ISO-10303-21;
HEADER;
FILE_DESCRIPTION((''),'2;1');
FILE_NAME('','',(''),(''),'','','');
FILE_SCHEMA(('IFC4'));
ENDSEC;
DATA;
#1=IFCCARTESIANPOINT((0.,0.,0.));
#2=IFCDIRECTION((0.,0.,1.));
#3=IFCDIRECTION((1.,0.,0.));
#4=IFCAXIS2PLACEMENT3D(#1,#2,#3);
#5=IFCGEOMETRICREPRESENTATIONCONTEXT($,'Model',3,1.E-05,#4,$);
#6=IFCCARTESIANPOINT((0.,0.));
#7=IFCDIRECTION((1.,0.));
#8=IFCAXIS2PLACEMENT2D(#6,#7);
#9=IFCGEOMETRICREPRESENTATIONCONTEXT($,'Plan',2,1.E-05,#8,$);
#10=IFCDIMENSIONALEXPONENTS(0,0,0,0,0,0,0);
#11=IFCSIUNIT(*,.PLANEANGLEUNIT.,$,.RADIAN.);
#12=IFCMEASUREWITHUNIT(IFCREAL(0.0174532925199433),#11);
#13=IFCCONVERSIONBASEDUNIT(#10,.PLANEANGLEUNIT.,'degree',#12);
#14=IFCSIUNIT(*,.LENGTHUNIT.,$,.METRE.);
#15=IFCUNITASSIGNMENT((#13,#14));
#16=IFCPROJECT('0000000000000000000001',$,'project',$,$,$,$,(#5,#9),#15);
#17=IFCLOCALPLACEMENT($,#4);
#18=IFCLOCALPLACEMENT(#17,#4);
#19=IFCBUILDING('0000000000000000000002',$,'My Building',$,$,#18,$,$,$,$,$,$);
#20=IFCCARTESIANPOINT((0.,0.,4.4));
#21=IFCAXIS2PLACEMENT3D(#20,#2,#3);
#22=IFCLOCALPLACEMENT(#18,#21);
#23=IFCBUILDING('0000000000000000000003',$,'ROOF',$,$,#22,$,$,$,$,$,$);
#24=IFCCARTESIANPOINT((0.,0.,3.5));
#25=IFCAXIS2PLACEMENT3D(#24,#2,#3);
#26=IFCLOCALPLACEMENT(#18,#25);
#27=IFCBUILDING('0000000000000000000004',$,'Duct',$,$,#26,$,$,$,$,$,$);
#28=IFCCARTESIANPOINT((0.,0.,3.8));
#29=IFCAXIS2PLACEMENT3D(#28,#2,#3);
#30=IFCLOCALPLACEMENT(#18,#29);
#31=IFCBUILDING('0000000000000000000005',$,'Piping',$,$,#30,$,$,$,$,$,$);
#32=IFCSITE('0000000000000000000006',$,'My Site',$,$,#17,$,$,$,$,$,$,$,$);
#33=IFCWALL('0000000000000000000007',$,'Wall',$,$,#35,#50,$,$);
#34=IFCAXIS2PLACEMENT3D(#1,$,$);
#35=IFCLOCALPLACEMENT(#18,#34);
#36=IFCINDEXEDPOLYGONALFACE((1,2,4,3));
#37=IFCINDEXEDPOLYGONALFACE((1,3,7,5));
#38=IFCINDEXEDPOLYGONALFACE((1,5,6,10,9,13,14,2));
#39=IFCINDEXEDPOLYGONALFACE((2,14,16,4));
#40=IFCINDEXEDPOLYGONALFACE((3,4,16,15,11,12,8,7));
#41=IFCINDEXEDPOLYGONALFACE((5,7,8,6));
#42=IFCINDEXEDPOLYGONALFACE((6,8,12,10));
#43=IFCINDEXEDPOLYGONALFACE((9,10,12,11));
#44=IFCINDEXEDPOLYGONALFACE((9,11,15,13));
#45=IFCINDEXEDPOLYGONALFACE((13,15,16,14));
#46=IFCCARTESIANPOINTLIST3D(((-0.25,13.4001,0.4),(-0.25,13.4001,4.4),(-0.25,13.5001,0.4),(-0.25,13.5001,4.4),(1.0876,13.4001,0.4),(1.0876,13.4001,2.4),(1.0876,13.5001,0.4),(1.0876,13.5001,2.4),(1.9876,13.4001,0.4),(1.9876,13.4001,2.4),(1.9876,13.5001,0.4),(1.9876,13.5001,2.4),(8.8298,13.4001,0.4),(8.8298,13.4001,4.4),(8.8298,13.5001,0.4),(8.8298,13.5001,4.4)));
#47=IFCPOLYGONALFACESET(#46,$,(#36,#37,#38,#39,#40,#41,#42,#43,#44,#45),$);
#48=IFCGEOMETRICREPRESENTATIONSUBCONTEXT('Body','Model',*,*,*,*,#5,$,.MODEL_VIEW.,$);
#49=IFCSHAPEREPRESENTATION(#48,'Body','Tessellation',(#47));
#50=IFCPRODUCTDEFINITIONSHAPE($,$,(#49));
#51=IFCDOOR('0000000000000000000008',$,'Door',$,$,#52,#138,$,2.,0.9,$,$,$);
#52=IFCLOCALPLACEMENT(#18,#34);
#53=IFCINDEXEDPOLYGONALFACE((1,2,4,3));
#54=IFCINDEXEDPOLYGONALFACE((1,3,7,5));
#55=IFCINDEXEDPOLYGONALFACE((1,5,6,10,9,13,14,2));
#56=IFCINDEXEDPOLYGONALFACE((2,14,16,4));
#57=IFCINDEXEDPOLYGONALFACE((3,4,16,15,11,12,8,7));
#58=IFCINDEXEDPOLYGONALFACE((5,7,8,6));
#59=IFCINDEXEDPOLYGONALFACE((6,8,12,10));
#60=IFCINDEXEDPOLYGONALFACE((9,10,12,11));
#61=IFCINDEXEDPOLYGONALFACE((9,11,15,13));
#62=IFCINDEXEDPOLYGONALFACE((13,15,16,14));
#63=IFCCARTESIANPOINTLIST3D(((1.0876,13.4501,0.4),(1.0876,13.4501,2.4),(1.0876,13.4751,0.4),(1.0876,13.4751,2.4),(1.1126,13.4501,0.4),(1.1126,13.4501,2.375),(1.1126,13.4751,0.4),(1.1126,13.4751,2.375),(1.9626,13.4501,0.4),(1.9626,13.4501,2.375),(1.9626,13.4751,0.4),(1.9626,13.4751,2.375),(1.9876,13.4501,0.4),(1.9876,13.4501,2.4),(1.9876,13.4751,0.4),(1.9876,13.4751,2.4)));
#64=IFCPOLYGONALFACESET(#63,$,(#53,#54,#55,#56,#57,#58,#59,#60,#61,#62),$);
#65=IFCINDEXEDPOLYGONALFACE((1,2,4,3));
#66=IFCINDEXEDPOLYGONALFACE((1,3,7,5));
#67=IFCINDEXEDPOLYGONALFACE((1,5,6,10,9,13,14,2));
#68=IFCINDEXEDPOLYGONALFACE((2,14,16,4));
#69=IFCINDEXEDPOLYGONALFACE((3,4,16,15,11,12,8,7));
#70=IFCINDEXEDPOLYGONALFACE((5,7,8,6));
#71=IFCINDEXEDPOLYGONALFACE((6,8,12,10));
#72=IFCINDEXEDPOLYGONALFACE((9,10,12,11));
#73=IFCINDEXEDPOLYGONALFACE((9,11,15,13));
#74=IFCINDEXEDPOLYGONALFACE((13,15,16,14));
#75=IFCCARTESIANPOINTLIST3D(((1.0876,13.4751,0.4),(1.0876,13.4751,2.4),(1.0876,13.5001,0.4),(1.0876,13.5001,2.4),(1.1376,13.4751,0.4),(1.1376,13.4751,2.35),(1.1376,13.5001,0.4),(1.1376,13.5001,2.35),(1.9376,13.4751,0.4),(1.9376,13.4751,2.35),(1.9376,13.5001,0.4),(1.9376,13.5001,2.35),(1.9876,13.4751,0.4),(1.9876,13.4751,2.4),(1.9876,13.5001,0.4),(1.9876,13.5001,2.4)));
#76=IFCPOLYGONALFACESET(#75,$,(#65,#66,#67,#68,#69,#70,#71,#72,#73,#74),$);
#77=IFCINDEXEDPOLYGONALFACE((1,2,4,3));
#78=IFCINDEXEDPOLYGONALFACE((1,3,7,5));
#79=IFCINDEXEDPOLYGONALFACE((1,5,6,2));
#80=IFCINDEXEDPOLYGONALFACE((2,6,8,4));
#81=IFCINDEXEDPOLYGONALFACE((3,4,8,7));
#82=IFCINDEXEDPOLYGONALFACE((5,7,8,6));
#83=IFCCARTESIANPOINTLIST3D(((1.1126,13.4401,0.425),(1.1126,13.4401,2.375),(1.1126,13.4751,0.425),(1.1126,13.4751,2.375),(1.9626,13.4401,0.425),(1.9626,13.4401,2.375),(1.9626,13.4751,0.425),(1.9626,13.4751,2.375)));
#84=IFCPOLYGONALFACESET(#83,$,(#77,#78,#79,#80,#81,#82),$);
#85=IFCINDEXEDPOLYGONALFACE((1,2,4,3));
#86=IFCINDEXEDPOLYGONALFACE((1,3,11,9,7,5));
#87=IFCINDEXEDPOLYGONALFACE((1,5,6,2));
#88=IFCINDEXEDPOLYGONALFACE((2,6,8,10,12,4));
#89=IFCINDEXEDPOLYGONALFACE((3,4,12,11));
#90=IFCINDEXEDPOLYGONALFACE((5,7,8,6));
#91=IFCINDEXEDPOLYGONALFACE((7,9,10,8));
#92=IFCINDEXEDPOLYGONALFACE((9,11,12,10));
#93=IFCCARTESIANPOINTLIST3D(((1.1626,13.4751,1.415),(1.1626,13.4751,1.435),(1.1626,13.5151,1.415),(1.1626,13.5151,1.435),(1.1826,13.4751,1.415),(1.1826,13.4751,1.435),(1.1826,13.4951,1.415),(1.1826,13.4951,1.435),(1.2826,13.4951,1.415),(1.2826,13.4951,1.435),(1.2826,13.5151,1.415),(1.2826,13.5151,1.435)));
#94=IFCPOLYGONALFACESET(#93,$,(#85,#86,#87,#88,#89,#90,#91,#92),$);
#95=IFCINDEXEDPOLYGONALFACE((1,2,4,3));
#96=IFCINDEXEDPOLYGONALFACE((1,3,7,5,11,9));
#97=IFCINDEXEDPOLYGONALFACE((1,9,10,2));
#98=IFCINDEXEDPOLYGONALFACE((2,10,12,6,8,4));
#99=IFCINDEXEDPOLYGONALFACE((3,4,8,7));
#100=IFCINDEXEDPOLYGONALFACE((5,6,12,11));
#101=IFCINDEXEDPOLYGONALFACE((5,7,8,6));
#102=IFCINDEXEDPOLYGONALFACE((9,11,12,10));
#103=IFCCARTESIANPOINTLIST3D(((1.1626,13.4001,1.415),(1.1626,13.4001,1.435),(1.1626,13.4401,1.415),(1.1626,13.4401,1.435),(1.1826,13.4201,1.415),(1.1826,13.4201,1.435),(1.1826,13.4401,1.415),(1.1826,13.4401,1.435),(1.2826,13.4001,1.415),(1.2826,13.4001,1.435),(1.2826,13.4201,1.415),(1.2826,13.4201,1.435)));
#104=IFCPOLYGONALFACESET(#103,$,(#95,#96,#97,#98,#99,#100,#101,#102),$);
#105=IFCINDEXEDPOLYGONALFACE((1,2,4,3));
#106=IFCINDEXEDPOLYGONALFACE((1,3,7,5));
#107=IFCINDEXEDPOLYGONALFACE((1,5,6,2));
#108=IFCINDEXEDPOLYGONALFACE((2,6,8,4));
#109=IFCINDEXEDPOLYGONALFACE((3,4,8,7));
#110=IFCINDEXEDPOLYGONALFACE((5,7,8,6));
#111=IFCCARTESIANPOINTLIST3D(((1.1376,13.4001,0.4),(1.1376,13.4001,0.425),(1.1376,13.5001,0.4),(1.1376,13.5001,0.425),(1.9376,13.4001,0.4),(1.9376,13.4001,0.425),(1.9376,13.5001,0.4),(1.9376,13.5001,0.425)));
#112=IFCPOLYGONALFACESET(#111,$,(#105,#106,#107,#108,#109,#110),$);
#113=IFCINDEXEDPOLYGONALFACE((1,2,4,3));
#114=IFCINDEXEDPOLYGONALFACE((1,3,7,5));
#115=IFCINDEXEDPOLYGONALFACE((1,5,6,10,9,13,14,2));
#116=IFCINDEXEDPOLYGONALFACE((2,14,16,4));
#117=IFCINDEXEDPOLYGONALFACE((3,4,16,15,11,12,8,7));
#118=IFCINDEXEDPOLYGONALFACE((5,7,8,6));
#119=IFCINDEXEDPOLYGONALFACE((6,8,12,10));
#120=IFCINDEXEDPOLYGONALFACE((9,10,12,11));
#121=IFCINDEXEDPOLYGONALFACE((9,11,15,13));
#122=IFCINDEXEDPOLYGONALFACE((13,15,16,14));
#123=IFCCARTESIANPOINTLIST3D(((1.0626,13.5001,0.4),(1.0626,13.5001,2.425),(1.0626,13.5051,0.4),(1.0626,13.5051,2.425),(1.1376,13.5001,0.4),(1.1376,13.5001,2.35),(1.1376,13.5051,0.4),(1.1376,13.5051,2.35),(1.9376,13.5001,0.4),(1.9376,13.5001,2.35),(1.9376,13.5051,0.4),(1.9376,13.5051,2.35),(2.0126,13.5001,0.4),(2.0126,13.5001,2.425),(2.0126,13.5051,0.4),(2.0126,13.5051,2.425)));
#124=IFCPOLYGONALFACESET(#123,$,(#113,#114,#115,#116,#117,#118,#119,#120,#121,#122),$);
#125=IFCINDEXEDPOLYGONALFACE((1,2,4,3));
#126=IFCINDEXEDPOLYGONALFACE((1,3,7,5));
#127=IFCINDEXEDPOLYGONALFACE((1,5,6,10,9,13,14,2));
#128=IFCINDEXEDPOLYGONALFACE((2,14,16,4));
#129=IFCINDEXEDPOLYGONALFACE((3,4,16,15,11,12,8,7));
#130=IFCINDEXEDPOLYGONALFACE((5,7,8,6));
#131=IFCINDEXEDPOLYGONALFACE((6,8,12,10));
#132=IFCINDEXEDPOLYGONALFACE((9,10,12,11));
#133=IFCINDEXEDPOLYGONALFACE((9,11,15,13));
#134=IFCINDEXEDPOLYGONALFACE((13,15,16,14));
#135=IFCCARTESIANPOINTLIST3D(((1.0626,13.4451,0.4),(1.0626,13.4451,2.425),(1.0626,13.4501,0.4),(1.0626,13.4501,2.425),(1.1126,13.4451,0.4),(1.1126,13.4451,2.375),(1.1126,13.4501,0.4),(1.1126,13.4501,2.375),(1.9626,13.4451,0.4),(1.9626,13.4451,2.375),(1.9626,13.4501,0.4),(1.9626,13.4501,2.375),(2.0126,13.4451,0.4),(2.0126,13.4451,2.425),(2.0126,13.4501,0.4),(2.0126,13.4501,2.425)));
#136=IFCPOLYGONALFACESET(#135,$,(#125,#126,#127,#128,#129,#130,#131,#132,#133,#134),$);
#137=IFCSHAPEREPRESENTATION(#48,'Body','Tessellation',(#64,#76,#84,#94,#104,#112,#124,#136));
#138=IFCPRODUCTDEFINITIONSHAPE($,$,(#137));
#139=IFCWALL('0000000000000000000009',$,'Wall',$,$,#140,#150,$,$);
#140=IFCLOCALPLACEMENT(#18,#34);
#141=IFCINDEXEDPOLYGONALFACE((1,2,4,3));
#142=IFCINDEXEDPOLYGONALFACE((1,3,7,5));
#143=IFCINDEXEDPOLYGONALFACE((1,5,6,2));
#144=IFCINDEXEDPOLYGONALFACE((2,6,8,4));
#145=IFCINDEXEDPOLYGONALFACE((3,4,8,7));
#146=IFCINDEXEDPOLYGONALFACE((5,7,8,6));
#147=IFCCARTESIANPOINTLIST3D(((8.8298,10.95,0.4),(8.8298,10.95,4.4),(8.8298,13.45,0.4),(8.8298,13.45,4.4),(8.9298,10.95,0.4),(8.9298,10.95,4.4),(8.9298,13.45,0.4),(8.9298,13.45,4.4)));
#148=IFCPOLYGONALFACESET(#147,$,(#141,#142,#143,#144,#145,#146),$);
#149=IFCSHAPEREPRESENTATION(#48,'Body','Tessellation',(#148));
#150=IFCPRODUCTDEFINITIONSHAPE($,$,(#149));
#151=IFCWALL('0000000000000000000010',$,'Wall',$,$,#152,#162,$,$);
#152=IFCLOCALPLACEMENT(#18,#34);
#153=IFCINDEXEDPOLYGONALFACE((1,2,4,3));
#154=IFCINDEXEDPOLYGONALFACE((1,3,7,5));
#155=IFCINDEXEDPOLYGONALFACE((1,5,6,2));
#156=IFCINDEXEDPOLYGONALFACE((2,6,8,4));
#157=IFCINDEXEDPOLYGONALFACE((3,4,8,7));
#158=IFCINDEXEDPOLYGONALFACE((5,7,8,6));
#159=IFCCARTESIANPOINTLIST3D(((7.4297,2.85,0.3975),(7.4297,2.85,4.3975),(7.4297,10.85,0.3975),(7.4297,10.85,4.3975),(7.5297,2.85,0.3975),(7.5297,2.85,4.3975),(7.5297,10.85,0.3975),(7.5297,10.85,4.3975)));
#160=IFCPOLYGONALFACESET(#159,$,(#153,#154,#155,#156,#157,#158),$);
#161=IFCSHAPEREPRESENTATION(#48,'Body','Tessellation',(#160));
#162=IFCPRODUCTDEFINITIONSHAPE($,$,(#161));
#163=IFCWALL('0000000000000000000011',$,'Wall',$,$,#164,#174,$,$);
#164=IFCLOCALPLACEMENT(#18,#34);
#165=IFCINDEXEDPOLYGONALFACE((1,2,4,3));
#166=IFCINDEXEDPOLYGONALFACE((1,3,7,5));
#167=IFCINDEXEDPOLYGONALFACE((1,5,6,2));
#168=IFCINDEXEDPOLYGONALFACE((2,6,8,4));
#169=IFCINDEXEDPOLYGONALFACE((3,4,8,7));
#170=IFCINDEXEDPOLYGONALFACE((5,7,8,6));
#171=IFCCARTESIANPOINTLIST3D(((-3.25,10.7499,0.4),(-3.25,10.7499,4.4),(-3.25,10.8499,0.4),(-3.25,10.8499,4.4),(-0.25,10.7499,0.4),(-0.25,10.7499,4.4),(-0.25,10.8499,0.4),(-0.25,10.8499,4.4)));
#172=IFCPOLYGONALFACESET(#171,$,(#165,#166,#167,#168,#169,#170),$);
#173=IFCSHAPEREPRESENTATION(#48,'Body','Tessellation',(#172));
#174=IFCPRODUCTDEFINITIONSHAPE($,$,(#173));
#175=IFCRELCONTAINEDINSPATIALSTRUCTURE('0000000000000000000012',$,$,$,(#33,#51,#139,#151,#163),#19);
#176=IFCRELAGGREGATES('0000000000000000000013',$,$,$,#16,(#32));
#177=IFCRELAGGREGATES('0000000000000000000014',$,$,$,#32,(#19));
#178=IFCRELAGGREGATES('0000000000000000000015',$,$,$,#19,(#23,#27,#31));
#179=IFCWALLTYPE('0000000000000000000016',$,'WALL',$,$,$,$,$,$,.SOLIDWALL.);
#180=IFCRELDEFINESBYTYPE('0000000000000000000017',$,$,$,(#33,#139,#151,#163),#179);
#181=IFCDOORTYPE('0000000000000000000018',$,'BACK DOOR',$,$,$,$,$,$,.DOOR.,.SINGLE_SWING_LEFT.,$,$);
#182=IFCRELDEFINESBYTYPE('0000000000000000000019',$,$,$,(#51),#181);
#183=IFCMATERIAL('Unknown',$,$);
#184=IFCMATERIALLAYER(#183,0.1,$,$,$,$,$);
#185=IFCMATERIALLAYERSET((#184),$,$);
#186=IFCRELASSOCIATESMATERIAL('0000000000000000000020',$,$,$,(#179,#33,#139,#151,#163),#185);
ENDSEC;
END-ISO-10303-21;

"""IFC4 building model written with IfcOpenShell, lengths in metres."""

from ifc_helpers import new_model, entity, si_unit, converted_unit, frame, origin_with_axes, origin_2d_with_axis, place, context, subcontext, project, spatial, line, indexed_curve, outline, extrude, shape, source, transform, mapped, material, layer, layer_set, layer_usage, type_object, type_shapes, element, fill, save


model = new_model("IFC4")

# Units and contexts
model_context = context("Model", 3, precision=1e-05, world=origin_with_axes())
plan_context = context("Plan", 2, precision=1e-05, world=origin_2d_with_axis())
body_context_1 = subcontext(model_context, "Body", "Model", "MODEL_VIEW")
body_context_2 = subcontext(plan_context, "Body", "Plan", "PLAN_VIEW")
ifc_project = project(units=[converted_unit("PLANEANGLEUNIT", "degree", entity("IfcReal", 0.0174532925199433), si_unit("PLANEANGLEUNIT", "RADIAN"), dimensions=[0, 0, 0, 0, 0, 0, 0]), si_unit("LENGTHUNIT", "METRE")], contexts=[model_context, plan_context])

# Site, building
site_placement = place(None, origin_with_axes())
site = spatial("IfcSite", under=ifc_project, at=site_placement, Name="My Site")
building_1_placement = place(site_placement, origin_with_axes())
building_1 = spatial("IfcBuilding", under=site, at=building_1_placement, Name="My Building")

# Shared definitions
ifc_material = material(Name="Unknown")

# Shared definitions
building_2_placement = place(building_1_placement, frame((0.0, 0.0, 4.4), z_axis=(0.0, 0.0, 1.0), x_axis=(1.0, 0.0, 0.0)))
building_2 = spatial("IfcBuilding", under=building_1, at=building_2_placement, Name="ROOF")

# Shared definitions
ifc_layer_1 = layer(ifc_material, 0.1)
ifc_layer_set_1 = layer_set([ifc_layer_1])
wall_type_1 = type_object("IfcWallType", Name="WALL", PredefinedType="SOLIDWALL", material=ifc_layer_set_1)
shared_shape_1 = source(origin_with_axes(), body_context_1, "Body", "SweptSolid", [
    extrude(outline(indexed_curve([(0.0, 0.0), (0.9, 0.0), (0.9, 2.0), (0.0, 2.0)], segments=[line(1, 2, 3, 4, 1)])), frame((0.0, -0.6, 0.0), z_axis=(0.0, -1.0, 0.0), x_axis=(1.0, 0.0, 0.0)), (0.0, 0.0, -1.0), 1.2),
])
door_type = type_object("IfcDoorType", Name="BACK DOOR", OperationType="SINGLE_SWING_LEFT", PredefinedType="DOOR")
shared_shape_2 = source(origin_with_axes(), body_context_1, "Body", "SweptSolid", [
    extrude(outline(indexed_curve([(0.0, 0.0), (0.0, 2.0), (0.9, 2.0), (0.9, 0.0), (0.875, 0.0), (0.875, 1.975), (0.025, 1.975), (0.025, 0.0)], segments=[line(1, 2, 3, 4, 5, 6, 7, 8, 1)])), frame((0.0, 0.025, 0.0), z_axis=(0.0, -1.0, 0.0), x_axis=(1.0, 0.0, 0.0)), (0.0, 0.0, -1.0), 0.025),
    extrude(outline(indexed_curve([(0.0, 0.0), (0.0, 2.0), (0.9, 2.0), (0.9, 0.0), (0.85, 0.0), (0.85, 1.95), (0.05, 1.95), (0.05, 0.0)], segments=[line(1, 2, 3, 4, 5, 6, 7, 8, 1)])), frame((0.0, 0.0, 0.0), z_axis=(0.0, -1.0, 0.0), x_axis=(1.0, 0.0, 0.0)), (0.0, 0.0, -1.0), 0.025),
    extrude(outline(indexed_curve([(0.0, 0.0), (0.85, 0.0), (0.85, 0.035), (0.0, 0.035)], segments=[line(1, 2, 3, 4, 1)])), frame((0.025, 0.025, 0.025), z_axis=(0.0, 0.0, 1.0), x_axis=(1.0, 0.0, 0.0)), (0.0, 0.0, 1.0), 1.95),
    extrude(outline(indexed_curve([(0.0, 0.0), (0.0, -0.04), (-0.12, -0.04), (-0.12, -0.02), (-0.02, -0.02), (-0.02, 0.0)], segments=[line(1, 2, 3, 4, 5, 6, 1)])), frame((0.825, 0.025, 1.015), z_axis=(0.0, 0.0, 1.0), x_axis=(1.0, 0.0, 0.0)), (0.0, 0.0, 1.0), 0.02),
    extrude(outline(indexed_curve([(0.0, 0.0), (0.0, 0.04), (-0.12, 0.04), (-0.12, 0.02), (-0.02, 0.02), (-0.02, 0.0)], segments=[line(1, 2, 3, 4, 5, 6, 1)])), frame((0.825, 0.06, 1.015), z_axis=(0.0, 0.0, 1.0), x_axis=(1.0, 0.0, 0.0)), (0.0, 0.0, 1.0), 0.02),
    extrude(outline(indexed_curve([(0.0, 0.0), (0.8, 0.0), (0.8, 0.1), (0.0, 0.1)], segments=[line(1, 2, 3, 4, 1)])), frame((0.05, 0.0, 0.0), z_axis=(0.0, 0.0, 1.0), x_axis=(1.0, 0.0, 0.0)), (0.0, 0.0, 1.0), 0.025),
    extrude(outline(indexed_curve([(0.0, 0.0), (0.0, 2.025), (0.95, 2.025), (0.95, 0.0), (0.875, 0.0), (0.875, 1.95), (0.075, 1.95), (0.075, 0.0)], segments=[line(1, 2, 3, 4, 5, 6, 7, 8, 1)])), frame((-0.025, -0.005, 0.0), z_axis=(0.0, -1.0, 0.0), x_axis=(1.0, 0.0, 0.0)), (0.0, 0.0, -1.0), 0.005),
    extrude(outline(indexed_curve([(0.0, 0.0), (0.0, 2.025), (0.95, 2.025), (0.95, 0.0), (0.9, 0.0), (0.9, 1.975), (0.05, 1.975), (0.05, 0.0)], segments=[line(1, 2, 3, 4, 5, 6, 7, 8, 1)])), frame((-0.025, 0.05, 0.0), z_axis=(0.0, -1.0, 0.0), x_axis=(1.0, 0.0, 0.0)), (0.0, 0.0, -1.0), 0.005),
])
shared_shape_3 = source(origin_with_axes(), body_context_2, "Body", "Curve2D", [
    entity("IfcIndexedPolyCurve", entity("IfcCartesianPointList2D", [[0.0, 0.0], [0.0, 0.05], [0.025, 0.05], [0.025, 0.025], [0.05, 0.025], [0.05, 0.0]]), [entity("IfcLineIndex", [1, 2, 3, 4, 5, 6, 1])]),
    entity("IfcIndexedPolyCurve", entity("IfcCartesianPointList2D", [[0.9, 0.0], [0.9, 0.05], [0.875, 0.05], [0.875, 0.025], [0.85, 0.025], [0.85, 0.0]]), [entity("IfcLineIndex", [1, 2, 3, 4, 5, 6, 1])]),
    entity("IfcTrimmedCurve", entity("IfcEllipse", entity("IfcAxis2Placement2D", entity("IfcCartesianPoint", [0.06, 0.05]), entity("IfcDirection", [1.0, 0.0])), 0.815, 0.85), [entity("IfcCartesianPoint", [0.875, 0.05])], [entity("IfcCartesianPoint", [0.06, 0.9])], True, "CARTESIAN"),
    entity("IfcIndexedPolyCurve", entity("IfcCartesianPointList2D", [[0.025, 0.05], [0.06, 0.05], [0.06, 0.9], [0.025, 0.9]]), [entity("IfcLineIndex", [1, 2, 3, 4, 1])]),
])
type_shapes(door_type, [shared_shape_2, shared_shape_3])

# Wall, opening, door
ifc_layer_usage_1 = layer_usage(ifc_layer_set_1, "AXIS2", "POSITIVE", 0.0)
wall_1_placement = place(building_1_placement, frame((8.8298, 13.5001, 0.4), z_axis=(0.0, 0.0, 1.0), x_axis=(-1.0, 0.0, 0.0)))
wall_1 = element("IfcWall", 1, at=wall_1_placement, inside=building_1, type_object=wall_type_1, material=ifc_layer_usage_1, Name="Wall", context=body_context_1, shape_type="SweptSolid", body=[
    extrude(outline(indexed_curve([(0.0, 0.0), (0.0, 0.1), (9.0798, 0.1), (9.0798, 0.0)], segments=[line(1, 2, 3, 4, 1)])), origin_with_axes(), (0.0, 0.0, 1.0), 4.0),
])
opening_1_placement = place(wall_1_placement, frame((6.8422, 0.0, 0.0), z_axis=(0.0, 0.0, 1.0), x_axis=(1.0, 0.0, 0.0)))
opening_1 = element("IfcOpeningElement", 2, at=opening_1_placement, cuts=wall_1, PredefinedType="OPENING", context=body_context_1, shape_type="MappedRepresentation", body=[
    mapped(shared_shape_1, transform((0.0, 0.0, 0.0), x_axis=(1.0, 0.0, 0.0), y_axis=(0.0, 1.0, 0.0), z_axis=(0.0, 0.0, 1.0), scale=1.0)),
])
door_1_placement = place(opening_1_placement, frame((0.0, 0.0, 0.0), z_axis=(0.0, 0.0, 1.0), x_axis=(1.0, 0.0, 0.0)))
door_1 = element("IfcDoor", 3, at=door_1_placement, inside=building_1, type_object=door_type, Name="Door", OverallHeight=2.0, OverallWidth=0.9, shapes=[
    shape(body_context_1, "Body", "MappedRepresentation", [mapped(shared_shape_2, transform((0.0, 0.0, 0.0), x_axis=(1.0, 0.0, 0.0), y_axis=(0.0, 1.0, 0.0), z_axis=(0.0, 0.0, 1.0), scale=1.0))]),
    shape(body_context_2, "Body", "MappedRepresentation", [mapped(shared_shape_3, transform((0.0, 0.0, 0.0), x_axis=(1.0, 0.0, 0.0), y_axis=(0.0, 1.0, 0.0), z_axis=(0.0, 0.0, 1.0), scale=1.0))]),
])
fill(opening_1, door_1)

# Walls
ifc_layer_usage_2 = layer_usage(ifc_layer_set_1, "AXIS2", "POSITIVE", 0.0)
wall_2_placement = place(building_1_placement, frame((8.8298, 13.45, 0.4), z_axis=(0.0, 0.0, 1.0), x_axis=(0.0, -1.0, 0.0)))
element("IfcWall", 4, at=wall_2_placement, inside=building_1, type_object=wall_type_1, material=ifc_layer_usage_2, Name="Wall", context=body_context_1, shape_type="SweptSolid", body=[
    extrude(outline(indexed_curve([(0.0, 0.0), (0.0, 0.1), (2.5, 0.1), (2.5, 0.0)], segments=[line(1, 2, 3, 4, 1)])), origin_with_axes(), (0.0, 0.0, 1.0), 4.0),
])
ifc_layer_usage_3 = layer_usage(ifc_layer_set_1, "AXIS2", "POSITIVE", 0.0)
wall_3_placement = place(building_1_placement, frame((7.4297, 10.85, 0.3975), z_axis=(0.0, 0.0, 1.0), x_axis=(0.0, -1.0, 0.0)))
element("IfcWall", 5, at=wall_3_placement, inside=building_1, type_object=wall_type_1, material=ifc_layer_usage_3, Name="Wall", context=body_context_1, shape_type="SweptSolid", body=[
    extrude(outline(indexed_curve([(0.0, 0.0), (0.0, 0.1), (8.0, 0.1), (8.0, 0.0)], segments=[line(1, 2, 3, 4, 1)])), origin_with_axes(), (0.0, 0.0, 1.0), 4.0),
])
ifc_layer_usage_4 = layer_usage(ifc_layer_set_1, "AXIS2", "POSITIVE", 0.0)
wall_4_placement = place(building_1_placement, frame((-3.25, 10.7499, 0.4), z_axis=(0.0, 0.0, 1.0), x_axis=(1.0, 0.0, 0.0)))
element("IfcWall", 6, at=wall_4_placement, inside=building_1, type_object=wall_type_1, material=ifc_layer_usage_4, Name="Wall", context=body_context_1, shape_type="SweptSolid", body=[
    extrude(outline(indexed_curve([(0.0, 0.0), (0.0, 0.1), (3.0, 0.1), (3.0, 0.0)], segments=[line(1, 2, 3, 4, 1)])), origin_with_axes(), (0.0, 0.0, 1.0), 4.0),
])

# Shared definitions
building_3_placement = place(building_1_placement, frame((0.0, 0.0, 3.5), z_axis=(0.0, 0.0, 1.0), x_axis=(1.0, 0.0, 0.0)))
building_3 = spatial("IfcBuilding", under=building_1, at=building_3_placement, Name="Duct")

# Shared definitions
building_4_placement = place(building_1_placement, frame((0.0, 0.0, 3.8), z_axis=(0.0, 0.0, 1.0), x_axis=(1.0, 0.0, 0.0)))
building_4 = spatial("IfcBuilding", under=building_1, at=building_4_placement, Name="Piping")

save(model, "model.ifc")
